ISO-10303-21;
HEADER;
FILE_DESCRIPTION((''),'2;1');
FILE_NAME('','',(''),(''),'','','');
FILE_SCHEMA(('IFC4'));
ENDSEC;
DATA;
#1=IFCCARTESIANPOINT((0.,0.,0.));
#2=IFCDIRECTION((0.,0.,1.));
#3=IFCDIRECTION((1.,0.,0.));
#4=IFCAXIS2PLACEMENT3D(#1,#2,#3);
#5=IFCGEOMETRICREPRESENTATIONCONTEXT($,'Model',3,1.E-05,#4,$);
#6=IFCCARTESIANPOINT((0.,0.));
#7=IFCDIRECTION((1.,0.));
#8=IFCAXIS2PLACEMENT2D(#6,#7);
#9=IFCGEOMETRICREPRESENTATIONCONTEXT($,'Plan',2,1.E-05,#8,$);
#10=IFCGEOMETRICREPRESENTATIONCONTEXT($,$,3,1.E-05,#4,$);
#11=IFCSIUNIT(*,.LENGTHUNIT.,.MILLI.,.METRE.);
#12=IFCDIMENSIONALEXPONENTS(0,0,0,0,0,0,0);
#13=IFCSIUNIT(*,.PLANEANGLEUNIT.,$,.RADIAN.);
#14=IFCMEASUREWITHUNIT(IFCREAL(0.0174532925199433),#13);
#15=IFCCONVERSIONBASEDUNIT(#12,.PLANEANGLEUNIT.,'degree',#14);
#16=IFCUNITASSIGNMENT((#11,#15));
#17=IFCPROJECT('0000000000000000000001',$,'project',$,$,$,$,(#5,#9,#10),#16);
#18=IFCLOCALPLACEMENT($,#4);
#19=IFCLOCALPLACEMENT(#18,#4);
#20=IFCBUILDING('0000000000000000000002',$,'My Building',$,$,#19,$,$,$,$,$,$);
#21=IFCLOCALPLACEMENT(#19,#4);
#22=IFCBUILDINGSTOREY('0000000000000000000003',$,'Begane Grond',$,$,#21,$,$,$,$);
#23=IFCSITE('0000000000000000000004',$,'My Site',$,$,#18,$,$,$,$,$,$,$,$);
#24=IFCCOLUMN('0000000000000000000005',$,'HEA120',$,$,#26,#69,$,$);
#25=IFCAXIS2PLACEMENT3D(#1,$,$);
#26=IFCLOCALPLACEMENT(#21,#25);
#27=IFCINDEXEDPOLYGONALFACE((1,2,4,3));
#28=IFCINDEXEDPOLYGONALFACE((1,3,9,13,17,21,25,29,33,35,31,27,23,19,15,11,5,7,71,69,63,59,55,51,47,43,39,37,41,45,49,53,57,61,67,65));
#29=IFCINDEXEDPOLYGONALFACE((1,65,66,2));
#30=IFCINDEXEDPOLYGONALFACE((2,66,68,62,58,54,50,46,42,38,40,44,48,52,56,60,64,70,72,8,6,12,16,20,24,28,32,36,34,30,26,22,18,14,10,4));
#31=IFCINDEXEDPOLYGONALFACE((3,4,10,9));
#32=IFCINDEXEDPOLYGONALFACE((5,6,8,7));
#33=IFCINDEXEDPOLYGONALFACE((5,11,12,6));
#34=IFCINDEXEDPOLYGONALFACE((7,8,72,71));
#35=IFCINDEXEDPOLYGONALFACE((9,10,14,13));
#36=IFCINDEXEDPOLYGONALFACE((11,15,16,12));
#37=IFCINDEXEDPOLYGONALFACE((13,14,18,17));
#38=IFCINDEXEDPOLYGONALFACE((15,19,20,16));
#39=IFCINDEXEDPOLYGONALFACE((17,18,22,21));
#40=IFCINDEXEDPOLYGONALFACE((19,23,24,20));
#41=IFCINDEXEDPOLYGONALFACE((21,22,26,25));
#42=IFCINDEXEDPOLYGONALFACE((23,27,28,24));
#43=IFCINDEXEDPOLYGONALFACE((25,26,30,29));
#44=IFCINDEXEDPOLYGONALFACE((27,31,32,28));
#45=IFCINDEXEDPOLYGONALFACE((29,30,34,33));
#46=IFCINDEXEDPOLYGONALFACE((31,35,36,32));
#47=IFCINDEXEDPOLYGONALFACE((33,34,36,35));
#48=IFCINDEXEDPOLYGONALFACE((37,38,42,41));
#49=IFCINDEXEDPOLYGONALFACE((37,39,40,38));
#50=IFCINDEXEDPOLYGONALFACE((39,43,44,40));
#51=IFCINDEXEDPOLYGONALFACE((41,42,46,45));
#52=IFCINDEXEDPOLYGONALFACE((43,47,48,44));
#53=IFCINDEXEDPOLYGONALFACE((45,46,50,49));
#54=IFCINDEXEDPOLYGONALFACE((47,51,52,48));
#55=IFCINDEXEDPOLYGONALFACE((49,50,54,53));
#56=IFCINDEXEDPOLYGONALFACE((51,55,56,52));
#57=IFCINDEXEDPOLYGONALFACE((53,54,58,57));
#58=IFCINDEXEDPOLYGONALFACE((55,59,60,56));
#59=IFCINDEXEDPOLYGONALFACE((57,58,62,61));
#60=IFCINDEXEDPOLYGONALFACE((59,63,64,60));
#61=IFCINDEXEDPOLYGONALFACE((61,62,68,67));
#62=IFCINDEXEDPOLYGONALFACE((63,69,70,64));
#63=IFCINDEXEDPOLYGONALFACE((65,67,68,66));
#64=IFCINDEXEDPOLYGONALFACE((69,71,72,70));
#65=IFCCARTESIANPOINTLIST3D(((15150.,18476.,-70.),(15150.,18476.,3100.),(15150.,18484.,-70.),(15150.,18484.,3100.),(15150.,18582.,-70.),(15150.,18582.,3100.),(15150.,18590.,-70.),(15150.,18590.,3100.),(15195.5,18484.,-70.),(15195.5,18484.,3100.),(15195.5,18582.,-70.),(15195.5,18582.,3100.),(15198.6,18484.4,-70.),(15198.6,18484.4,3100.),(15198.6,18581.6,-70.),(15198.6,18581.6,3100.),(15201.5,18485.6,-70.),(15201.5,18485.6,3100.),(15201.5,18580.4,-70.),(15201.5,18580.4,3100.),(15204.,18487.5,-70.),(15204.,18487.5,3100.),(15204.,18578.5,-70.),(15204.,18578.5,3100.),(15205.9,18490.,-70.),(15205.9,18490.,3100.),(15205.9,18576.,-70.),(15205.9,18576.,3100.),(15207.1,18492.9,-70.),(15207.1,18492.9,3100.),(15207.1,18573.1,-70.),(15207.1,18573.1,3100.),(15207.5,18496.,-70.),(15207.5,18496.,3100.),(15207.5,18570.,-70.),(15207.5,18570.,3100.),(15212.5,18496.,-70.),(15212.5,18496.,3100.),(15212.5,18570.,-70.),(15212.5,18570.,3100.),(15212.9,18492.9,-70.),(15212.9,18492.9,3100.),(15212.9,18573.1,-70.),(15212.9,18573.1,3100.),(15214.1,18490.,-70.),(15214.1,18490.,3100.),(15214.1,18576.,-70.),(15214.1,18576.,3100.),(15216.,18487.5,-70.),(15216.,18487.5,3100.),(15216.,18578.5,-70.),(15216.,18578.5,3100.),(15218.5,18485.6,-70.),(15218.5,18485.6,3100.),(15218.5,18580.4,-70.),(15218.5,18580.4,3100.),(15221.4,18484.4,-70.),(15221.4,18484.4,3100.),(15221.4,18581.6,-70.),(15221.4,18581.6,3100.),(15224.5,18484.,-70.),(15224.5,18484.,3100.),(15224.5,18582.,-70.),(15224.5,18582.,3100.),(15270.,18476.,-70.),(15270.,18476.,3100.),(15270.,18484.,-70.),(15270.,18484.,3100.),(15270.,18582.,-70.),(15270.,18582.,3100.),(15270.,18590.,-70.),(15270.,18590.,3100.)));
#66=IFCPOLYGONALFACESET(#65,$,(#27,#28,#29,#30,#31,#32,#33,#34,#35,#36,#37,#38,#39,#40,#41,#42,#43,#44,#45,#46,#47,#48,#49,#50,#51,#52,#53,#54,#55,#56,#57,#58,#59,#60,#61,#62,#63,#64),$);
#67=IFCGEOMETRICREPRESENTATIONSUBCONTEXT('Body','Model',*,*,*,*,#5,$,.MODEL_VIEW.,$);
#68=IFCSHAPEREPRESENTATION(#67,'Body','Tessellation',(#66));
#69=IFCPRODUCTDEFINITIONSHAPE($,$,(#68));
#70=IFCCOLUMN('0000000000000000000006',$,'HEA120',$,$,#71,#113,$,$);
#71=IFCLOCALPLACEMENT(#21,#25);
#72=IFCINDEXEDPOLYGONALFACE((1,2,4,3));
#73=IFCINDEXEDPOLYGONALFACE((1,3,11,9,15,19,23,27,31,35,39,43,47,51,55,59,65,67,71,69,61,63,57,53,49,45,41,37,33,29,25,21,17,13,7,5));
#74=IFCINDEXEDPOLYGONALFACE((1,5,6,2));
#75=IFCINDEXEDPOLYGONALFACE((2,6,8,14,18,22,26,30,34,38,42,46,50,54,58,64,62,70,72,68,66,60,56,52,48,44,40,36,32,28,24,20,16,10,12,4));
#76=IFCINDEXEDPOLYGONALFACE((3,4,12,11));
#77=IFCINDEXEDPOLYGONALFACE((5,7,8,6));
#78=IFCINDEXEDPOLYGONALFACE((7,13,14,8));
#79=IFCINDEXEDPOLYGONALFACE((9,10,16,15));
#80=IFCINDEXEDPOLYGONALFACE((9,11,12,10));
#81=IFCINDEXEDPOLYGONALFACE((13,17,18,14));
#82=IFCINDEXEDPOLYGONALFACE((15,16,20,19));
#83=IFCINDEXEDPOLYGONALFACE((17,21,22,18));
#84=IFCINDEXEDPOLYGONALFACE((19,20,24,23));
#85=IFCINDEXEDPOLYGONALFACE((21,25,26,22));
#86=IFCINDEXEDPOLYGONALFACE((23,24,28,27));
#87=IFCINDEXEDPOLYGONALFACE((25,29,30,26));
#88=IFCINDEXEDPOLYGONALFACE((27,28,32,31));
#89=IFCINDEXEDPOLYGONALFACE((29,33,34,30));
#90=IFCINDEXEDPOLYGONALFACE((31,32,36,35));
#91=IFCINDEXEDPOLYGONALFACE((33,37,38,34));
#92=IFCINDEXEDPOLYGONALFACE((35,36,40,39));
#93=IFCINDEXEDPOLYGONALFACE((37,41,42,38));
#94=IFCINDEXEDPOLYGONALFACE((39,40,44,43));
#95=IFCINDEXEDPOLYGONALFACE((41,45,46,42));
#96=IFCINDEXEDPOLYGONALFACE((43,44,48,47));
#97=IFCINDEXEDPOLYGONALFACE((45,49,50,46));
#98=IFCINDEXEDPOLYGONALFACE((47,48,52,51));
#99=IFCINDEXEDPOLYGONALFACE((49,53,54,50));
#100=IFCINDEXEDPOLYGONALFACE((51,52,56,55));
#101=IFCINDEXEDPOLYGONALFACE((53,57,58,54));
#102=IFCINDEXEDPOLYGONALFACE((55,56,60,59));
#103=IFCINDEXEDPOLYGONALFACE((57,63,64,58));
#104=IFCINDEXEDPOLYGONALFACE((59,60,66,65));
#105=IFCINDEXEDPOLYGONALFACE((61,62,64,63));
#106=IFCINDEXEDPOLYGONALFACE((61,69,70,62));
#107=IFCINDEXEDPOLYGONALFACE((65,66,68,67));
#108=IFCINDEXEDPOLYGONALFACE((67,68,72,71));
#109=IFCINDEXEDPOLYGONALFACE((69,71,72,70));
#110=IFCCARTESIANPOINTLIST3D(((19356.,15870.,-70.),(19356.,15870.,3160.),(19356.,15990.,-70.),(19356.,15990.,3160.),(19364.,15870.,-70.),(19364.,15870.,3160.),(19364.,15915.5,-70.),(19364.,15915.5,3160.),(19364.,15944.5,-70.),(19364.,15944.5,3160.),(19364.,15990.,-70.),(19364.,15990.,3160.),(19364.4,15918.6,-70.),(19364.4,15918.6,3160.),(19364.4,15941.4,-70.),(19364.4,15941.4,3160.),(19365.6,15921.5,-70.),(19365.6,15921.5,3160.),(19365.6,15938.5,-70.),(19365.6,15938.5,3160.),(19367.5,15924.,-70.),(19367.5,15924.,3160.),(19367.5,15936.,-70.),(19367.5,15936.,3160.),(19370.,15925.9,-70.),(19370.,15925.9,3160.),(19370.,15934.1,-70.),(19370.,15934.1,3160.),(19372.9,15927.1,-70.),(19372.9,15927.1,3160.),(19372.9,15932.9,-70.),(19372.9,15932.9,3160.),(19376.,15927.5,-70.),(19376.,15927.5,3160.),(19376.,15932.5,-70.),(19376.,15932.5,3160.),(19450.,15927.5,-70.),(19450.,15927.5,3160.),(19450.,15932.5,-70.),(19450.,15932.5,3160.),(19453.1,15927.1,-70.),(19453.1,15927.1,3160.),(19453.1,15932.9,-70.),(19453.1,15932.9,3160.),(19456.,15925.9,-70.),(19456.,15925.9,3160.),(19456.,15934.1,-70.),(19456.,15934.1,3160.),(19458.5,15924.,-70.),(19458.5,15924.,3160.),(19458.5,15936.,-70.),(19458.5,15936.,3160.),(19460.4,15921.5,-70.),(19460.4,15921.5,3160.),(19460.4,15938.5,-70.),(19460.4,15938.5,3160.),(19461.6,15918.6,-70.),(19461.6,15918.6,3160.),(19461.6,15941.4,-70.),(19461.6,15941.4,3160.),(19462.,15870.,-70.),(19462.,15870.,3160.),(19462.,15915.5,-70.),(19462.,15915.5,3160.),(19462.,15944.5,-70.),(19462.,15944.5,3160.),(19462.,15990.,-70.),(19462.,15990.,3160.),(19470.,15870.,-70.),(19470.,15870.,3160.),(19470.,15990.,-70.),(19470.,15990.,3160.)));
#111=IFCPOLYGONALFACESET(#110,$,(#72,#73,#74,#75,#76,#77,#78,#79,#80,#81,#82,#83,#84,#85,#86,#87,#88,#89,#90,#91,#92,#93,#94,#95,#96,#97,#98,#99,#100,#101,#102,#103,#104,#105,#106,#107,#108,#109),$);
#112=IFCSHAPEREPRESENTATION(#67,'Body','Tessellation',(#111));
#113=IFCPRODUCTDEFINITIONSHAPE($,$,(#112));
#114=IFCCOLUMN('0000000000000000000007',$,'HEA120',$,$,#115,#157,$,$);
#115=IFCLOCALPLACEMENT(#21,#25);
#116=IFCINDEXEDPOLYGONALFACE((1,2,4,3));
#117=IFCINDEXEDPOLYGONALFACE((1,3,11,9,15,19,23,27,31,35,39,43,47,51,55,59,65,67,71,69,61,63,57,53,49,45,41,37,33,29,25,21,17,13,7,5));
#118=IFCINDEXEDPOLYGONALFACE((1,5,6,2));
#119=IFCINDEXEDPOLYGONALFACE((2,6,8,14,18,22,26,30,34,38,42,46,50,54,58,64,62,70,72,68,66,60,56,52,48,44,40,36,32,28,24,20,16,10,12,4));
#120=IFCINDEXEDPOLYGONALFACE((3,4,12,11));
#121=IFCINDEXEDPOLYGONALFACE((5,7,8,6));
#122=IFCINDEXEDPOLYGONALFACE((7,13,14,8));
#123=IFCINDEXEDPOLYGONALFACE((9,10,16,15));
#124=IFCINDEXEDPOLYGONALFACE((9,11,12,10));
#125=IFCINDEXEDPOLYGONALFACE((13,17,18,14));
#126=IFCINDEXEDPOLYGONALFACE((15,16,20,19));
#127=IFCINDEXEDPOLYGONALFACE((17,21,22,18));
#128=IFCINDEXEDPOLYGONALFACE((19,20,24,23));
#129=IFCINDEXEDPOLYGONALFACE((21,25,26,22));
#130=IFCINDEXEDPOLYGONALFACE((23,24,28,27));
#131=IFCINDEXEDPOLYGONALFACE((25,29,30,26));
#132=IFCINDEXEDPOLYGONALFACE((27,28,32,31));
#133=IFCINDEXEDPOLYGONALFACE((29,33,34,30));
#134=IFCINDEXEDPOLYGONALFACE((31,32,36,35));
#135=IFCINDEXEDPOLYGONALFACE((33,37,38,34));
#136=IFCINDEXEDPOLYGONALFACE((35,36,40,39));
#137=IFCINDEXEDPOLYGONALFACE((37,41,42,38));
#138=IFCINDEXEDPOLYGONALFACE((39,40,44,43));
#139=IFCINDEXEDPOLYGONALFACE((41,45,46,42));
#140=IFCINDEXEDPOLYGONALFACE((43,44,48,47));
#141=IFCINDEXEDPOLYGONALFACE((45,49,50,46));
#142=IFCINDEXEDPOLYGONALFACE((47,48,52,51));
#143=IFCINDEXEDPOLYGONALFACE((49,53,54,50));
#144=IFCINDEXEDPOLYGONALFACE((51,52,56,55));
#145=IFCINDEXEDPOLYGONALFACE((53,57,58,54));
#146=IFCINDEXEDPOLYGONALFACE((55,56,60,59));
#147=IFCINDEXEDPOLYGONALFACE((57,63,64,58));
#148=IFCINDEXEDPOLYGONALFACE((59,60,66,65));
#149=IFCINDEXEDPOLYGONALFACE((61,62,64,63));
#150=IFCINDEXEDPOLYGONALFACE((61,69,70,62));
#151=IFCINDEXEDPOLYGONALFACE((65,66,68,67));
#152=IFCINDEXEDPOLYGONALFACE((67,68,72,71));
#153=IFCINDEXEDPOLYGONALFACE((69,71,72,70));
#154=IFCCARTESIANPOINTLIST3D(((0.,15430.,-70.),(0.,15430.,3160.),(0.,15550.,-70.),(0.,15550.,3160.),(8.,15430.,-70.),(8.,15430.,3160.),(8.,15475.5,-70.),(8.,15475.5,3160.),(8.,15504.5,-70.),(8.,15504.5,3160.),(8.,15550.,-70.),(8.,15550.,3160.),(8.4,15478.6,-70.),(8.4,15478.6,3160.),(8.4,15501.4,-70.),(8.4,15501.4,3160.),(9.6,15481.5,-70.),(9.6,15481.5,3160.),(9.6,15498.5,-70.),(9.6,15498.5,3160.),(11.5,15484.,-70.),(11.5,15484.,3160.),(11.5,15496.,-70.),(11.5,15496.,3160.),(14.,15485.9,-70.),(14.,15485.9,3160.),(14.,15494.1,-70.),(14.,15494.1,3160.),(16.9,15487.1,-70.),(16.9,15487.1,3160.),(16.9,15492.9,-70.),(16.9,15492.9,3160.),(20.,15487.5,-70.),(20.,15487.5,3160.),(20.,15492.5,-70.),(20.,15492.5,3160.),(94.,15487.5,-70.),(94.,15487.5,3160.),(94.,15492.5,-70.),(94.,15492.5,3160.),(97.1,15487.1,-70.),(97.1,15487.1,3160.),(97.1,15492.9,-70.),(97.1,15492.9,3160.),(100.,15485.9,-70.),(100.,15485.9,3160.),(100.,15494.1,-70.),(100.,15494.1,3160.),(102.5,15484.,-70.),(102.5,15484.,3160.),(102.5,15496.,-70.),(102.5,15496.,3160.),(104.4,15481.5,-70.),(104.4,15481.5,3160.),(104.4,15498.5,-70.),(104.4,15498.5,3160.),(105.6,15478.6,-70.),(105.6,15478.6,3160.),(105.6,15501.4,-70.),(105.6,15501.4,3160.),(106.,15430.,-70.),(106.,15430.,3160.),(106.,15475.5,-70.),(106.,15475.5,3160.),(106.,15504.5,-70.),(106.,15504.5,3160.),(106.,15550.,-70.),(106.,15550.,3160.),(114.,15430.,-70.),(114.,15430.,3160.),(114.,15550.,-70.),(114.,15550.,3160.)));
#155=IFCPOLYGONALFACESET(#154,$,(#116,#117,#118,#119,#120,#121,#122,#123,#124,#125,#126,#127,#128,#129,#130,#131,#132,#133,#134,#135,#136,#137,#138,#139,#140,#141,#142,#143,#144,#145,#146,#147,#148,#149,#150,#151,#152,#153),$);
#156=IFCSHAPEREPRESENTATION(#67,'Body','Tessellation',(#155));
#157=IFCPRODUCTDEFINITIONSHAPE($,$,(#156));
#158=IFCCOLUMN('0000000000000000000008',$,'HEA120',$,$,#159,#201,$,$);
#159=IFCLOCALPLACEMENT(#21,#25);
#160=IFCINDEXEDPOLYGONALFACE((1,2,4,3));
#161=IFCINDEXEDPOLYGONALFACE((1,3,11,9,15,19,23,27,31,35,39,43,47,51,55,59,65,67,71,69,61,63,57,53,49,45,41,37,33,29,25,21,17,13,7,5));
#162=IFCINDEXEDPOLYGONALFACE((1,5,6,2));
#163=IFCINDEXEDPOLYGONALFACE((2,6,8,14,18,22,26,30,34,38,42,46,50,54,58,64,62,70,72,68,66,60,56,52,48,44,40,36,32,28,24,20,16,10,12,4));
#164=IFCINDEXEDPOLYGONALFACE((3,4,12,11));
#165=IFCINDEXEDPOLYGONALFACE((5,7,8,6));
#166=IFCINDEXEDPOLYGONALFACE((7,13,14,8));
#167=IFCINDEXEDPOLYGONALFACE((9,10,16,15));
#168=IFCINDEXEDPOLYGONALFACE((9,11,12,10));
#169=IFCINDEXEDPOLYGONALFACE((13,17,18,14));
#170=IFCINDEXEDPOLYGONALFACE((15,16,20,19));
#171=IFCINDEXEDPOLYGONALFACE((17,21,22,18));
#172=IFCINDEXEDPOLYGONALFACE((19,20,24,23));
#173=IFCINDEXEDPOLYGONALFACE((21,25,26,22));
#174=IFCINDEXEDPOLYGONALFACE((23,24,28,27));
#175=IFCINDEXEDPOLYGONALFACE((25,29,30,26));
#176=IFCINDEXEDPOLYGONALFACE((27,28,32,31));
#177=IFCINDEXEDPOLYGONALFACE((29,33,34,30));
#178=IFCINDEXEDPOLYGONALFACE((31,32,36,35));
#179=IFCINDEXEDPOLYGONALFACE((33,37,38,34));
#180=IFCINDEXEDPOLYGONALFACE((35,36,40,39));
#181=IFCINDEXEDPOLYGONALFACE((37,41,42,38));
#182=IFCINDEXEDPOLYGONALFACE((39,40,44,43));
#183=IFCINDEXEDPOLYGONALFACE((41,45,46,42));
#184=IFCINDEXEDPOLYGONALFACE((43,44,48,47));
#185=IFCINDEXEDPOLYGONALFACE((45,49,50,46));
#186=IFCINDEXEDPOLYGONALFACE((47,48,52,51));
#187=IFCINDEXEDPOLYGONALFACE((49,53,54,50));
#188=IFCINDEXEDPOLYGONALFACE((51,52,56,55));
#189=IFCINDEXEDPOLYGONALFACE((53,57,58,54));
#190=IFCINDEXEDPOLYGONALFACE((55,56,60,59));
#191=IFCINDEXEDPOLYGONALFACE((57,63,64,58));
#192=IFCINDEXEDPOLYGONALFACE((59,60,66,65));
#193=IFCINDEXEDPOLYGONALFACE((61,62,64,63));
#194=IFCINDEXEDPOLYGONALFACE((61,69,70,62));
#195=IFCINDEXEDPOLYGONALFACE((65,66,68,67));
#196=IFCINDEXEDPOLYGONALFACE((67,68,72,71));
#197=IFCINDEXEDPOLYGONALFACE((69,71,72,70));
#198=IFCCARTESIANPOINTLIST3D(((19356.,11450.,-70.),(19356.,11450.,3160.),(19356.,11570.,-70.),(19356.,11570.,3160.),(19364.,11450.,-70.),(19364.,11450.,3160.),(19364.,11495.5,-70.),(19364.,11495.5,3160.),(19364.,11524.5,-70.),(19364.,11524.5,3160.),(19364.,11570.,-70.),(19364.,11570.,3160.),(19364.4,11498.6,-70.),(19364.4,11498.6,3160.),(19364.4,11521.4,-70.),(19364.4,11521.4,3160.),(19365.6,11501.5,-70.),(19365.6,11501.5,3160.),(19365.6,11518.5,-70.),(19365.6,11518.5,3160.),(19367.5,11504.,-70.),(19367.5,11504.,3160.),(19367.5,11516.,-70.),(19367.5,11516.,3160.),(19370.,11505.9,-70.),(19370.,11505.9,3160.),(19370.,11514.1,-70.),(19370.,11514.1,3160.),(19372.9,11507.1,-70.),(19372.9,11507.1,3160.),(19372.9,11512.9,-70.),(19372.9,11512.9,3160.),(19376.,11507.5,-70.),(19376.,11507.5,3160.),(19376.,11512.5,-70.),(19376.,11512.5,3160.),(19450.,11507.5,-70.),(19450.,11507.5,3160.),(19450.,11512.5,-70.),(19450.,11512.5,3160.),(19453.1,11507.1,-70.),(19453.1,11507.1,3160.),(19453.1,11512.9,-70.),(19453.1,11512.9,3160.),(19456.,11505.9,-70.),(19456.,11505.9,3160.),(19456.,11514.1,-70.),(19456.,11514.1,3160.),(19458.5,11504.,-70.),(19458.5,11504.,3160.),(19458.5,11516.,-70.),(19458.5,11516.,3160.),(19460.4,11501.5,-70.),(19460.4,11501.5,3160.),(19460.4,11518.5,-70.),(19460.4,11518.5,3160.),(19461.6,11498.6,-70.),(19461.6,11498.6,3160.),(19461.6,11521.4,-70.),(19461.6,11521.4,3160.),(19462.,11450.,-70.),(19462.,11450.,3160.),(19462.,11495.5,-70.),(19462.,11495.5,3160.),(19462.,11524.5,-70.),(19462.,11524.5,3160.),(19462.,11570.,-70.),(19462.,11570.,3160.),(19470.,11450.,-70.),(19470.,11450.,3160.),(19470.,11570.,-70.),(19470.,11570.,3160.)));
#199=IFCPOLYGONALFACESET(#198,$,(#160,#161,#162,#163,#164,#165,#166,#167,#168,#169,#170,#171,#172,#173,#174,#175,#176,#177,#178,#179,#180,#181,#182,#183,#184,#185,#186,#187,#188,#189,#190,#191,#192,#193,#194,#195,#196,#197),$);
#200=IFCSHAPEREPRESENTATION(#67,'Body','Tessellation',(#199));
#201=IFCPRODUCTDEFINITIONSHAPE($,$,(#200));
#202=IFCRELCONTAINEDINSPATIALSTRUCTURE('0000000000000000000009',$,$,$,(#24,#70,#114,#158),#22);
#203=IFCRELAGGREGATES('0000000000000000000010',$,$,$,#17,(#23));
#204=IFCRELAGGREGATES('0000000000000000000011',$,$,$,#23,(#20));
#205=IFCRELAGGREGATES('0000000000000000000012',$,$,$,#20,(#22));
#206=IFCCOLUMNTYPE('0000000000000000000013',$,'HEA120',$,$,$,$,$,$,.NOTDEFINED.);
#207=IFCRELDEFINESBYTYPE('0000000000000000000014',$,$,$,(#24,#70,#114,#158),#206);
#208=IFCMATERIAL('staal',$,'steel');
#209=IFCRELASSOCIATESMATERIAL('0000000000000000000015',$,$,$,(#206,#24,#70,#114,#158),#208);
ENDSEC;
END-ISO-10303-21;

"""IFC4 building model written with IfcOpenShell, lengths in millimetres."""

from ifc_helpers import new_model, entity, si_unit, converted_unit, frame, origin_with_axes, origin_2d_with_axis, place, context, subcontext, project, spatial, i_section, extrude, material, material_profile, profile_set, profile_usage, type_object, element, save


model = new_model("IFC4")

# Units and contexts
model_context = context("Model", 3, precision=1e-05, world=origin_with_axes())
plan_context = context("Plan", 2, precision=1e-05, world=origin_2d_with_axis())
context_of_model = context(None, 3, precision=1e-05, world=origin_with_axes())
body_context = subcontext(model_context, "Body", "Model", "MODEL_VIEW")
ifc_project = project(units=[si_unit("LENGTHUNIT", "METRE", prefix="MILLI"), converted_unit("PLANEANGLEUNIT", "degree", entity("IfcReal", 0.0174532925199433), si_unit("PLANEANGLEUNIT", "RADIAN"), dimensions=[0, 0, 0, 0, 0, 0, 0])], contexts=[model_context, plan_context, context_of_model])

# Site, building, storey
site_placement = place(None, origin_with_axes())
site = spatial("IfcSite", under=ifc_project, at=site_placement, Name="My Site")
building_placement = place(site_placement, origin_with_axes())
building = spatial("IfcBuilding", under=site, at=building_placement, Name="My Building")
storey_placement = place(building_placement, origin_with_axes())
storey = spatial("IfcBuildingStorey", under=building, at=storey_placement, Name="Begane Grond")

# Columns
ifc_material = material(Name="staal", Category="steel")
ifc_material_profile_1 = material_profile(ifc_material, i_section(OverallWidth=120.0, OverallDepth=114.0, WebThickness=5.0, FlangeThickness=8.0, FilletRadius=12.0))
ifc_profile_set_1 = profile_set([ifc_material_profile_1], Name="HEA120")
column_type_1 = type_object("IfcColumnType", Name="HEA120", PredefinedType="NOTDEFINED", material=ifc_profile_set_1)
ifc_profile_usage_1 = profile_usage(ifc_profile_set_1)
column_1_placement = place(storey_placement, frame((15210.0, 18533.0, -70.0), z_axis=(0.0, 0.0, 1.0), x_axis=(1.0, 0.0, 0.0)))
element("IfcColumn", 1, at=column_1_placement, inside=storey, type_object=column_type_1, material=ifc_profile_usage_1, Name="HEA120", context=body_context, shape_type="SweptSolid", body=[
    extrude(i_section(OverallWidth=120.0, OverallDepth=114.0, WebThickness=5.0, FlangeThickness=8.0, FilletRadius=12.0), origin_with_axes(), (0.0, 0.0, 1.0), 3170.0),
])
ifc_profile_usage_2 = profile_usage(ifc_profile_set_1)
column_2_placement = place(storey_placement, frame((19413.0, 15930.0, -70.0), z_axis=(0.0, 0.0, 1.0), x_axis=(0.0, 1.0, 0.0)))
element("IfcColumn", 2, at=column_2_placement, inside=storey, type_object=column_type_1, material=ifc_profile_usage_2, Name="HEA120", context=body_context, shape_type="SweptSolid", body=[
    extrude(i_section(OverallWidth=120.0, OverallDepth=114.0, WebThickness=5.0, FlangeThickness=8.0, FilletRadius=12.0), origin_with_axes(), (0.0, 0.0, 1.0), 3230.0),
])
ifc_profile_usage_3 = profile_usage(ifc_profile_set_1)
column_3_placement = place(storey_placement, frame((57.0, 15490.0, -70.0), z_axis=(0.0, 0.0, 1.0), x_axis=(0.0, 1.0, 0.0)))
element("IfcColumn", 3, at=column_3_placement, inside=storey, type_object=column_type_1, material=ifc_profile_usage_3, Name="HEA120", context=body_context, shape_type="SweptSolid", body=[
    extrude(i_section(OverallWidth=120.0, OverallDepth=114.0, WebThickness=5.0, FlangeThickness=8.0, FilletRadius=12.0), origin_with_axes(), (0.0, 0.0, 1.0), 3230.0),
])
ifc_profile_usage_4 = profile_usage(ifc_profile_set_1)
column_4_placement = place(storey_placement, frame((19413.0, 11510.0, -70.0), z_axis=(0.0, 0.0, 1.0), x_axis=(0.0, 1.0, 0.0)))
element("IfcColumn", 4, at=column_4_placement, inside=storey, type_object=column_type_1, material=ifc_profile_usage_4, Name="HEA120", context=body_context, shape_type="SweptSolid", body=[
    extrude(i_section(OverallWidth=120.0, OverallDepth=114.0, WebThickness=5.0, FlangeThickness=8.0, FilletRadius=12.0), origin_with_axes(), (0.0, 0.0, 1.0), 3230.0),
])

save(model, "model.ifc")
